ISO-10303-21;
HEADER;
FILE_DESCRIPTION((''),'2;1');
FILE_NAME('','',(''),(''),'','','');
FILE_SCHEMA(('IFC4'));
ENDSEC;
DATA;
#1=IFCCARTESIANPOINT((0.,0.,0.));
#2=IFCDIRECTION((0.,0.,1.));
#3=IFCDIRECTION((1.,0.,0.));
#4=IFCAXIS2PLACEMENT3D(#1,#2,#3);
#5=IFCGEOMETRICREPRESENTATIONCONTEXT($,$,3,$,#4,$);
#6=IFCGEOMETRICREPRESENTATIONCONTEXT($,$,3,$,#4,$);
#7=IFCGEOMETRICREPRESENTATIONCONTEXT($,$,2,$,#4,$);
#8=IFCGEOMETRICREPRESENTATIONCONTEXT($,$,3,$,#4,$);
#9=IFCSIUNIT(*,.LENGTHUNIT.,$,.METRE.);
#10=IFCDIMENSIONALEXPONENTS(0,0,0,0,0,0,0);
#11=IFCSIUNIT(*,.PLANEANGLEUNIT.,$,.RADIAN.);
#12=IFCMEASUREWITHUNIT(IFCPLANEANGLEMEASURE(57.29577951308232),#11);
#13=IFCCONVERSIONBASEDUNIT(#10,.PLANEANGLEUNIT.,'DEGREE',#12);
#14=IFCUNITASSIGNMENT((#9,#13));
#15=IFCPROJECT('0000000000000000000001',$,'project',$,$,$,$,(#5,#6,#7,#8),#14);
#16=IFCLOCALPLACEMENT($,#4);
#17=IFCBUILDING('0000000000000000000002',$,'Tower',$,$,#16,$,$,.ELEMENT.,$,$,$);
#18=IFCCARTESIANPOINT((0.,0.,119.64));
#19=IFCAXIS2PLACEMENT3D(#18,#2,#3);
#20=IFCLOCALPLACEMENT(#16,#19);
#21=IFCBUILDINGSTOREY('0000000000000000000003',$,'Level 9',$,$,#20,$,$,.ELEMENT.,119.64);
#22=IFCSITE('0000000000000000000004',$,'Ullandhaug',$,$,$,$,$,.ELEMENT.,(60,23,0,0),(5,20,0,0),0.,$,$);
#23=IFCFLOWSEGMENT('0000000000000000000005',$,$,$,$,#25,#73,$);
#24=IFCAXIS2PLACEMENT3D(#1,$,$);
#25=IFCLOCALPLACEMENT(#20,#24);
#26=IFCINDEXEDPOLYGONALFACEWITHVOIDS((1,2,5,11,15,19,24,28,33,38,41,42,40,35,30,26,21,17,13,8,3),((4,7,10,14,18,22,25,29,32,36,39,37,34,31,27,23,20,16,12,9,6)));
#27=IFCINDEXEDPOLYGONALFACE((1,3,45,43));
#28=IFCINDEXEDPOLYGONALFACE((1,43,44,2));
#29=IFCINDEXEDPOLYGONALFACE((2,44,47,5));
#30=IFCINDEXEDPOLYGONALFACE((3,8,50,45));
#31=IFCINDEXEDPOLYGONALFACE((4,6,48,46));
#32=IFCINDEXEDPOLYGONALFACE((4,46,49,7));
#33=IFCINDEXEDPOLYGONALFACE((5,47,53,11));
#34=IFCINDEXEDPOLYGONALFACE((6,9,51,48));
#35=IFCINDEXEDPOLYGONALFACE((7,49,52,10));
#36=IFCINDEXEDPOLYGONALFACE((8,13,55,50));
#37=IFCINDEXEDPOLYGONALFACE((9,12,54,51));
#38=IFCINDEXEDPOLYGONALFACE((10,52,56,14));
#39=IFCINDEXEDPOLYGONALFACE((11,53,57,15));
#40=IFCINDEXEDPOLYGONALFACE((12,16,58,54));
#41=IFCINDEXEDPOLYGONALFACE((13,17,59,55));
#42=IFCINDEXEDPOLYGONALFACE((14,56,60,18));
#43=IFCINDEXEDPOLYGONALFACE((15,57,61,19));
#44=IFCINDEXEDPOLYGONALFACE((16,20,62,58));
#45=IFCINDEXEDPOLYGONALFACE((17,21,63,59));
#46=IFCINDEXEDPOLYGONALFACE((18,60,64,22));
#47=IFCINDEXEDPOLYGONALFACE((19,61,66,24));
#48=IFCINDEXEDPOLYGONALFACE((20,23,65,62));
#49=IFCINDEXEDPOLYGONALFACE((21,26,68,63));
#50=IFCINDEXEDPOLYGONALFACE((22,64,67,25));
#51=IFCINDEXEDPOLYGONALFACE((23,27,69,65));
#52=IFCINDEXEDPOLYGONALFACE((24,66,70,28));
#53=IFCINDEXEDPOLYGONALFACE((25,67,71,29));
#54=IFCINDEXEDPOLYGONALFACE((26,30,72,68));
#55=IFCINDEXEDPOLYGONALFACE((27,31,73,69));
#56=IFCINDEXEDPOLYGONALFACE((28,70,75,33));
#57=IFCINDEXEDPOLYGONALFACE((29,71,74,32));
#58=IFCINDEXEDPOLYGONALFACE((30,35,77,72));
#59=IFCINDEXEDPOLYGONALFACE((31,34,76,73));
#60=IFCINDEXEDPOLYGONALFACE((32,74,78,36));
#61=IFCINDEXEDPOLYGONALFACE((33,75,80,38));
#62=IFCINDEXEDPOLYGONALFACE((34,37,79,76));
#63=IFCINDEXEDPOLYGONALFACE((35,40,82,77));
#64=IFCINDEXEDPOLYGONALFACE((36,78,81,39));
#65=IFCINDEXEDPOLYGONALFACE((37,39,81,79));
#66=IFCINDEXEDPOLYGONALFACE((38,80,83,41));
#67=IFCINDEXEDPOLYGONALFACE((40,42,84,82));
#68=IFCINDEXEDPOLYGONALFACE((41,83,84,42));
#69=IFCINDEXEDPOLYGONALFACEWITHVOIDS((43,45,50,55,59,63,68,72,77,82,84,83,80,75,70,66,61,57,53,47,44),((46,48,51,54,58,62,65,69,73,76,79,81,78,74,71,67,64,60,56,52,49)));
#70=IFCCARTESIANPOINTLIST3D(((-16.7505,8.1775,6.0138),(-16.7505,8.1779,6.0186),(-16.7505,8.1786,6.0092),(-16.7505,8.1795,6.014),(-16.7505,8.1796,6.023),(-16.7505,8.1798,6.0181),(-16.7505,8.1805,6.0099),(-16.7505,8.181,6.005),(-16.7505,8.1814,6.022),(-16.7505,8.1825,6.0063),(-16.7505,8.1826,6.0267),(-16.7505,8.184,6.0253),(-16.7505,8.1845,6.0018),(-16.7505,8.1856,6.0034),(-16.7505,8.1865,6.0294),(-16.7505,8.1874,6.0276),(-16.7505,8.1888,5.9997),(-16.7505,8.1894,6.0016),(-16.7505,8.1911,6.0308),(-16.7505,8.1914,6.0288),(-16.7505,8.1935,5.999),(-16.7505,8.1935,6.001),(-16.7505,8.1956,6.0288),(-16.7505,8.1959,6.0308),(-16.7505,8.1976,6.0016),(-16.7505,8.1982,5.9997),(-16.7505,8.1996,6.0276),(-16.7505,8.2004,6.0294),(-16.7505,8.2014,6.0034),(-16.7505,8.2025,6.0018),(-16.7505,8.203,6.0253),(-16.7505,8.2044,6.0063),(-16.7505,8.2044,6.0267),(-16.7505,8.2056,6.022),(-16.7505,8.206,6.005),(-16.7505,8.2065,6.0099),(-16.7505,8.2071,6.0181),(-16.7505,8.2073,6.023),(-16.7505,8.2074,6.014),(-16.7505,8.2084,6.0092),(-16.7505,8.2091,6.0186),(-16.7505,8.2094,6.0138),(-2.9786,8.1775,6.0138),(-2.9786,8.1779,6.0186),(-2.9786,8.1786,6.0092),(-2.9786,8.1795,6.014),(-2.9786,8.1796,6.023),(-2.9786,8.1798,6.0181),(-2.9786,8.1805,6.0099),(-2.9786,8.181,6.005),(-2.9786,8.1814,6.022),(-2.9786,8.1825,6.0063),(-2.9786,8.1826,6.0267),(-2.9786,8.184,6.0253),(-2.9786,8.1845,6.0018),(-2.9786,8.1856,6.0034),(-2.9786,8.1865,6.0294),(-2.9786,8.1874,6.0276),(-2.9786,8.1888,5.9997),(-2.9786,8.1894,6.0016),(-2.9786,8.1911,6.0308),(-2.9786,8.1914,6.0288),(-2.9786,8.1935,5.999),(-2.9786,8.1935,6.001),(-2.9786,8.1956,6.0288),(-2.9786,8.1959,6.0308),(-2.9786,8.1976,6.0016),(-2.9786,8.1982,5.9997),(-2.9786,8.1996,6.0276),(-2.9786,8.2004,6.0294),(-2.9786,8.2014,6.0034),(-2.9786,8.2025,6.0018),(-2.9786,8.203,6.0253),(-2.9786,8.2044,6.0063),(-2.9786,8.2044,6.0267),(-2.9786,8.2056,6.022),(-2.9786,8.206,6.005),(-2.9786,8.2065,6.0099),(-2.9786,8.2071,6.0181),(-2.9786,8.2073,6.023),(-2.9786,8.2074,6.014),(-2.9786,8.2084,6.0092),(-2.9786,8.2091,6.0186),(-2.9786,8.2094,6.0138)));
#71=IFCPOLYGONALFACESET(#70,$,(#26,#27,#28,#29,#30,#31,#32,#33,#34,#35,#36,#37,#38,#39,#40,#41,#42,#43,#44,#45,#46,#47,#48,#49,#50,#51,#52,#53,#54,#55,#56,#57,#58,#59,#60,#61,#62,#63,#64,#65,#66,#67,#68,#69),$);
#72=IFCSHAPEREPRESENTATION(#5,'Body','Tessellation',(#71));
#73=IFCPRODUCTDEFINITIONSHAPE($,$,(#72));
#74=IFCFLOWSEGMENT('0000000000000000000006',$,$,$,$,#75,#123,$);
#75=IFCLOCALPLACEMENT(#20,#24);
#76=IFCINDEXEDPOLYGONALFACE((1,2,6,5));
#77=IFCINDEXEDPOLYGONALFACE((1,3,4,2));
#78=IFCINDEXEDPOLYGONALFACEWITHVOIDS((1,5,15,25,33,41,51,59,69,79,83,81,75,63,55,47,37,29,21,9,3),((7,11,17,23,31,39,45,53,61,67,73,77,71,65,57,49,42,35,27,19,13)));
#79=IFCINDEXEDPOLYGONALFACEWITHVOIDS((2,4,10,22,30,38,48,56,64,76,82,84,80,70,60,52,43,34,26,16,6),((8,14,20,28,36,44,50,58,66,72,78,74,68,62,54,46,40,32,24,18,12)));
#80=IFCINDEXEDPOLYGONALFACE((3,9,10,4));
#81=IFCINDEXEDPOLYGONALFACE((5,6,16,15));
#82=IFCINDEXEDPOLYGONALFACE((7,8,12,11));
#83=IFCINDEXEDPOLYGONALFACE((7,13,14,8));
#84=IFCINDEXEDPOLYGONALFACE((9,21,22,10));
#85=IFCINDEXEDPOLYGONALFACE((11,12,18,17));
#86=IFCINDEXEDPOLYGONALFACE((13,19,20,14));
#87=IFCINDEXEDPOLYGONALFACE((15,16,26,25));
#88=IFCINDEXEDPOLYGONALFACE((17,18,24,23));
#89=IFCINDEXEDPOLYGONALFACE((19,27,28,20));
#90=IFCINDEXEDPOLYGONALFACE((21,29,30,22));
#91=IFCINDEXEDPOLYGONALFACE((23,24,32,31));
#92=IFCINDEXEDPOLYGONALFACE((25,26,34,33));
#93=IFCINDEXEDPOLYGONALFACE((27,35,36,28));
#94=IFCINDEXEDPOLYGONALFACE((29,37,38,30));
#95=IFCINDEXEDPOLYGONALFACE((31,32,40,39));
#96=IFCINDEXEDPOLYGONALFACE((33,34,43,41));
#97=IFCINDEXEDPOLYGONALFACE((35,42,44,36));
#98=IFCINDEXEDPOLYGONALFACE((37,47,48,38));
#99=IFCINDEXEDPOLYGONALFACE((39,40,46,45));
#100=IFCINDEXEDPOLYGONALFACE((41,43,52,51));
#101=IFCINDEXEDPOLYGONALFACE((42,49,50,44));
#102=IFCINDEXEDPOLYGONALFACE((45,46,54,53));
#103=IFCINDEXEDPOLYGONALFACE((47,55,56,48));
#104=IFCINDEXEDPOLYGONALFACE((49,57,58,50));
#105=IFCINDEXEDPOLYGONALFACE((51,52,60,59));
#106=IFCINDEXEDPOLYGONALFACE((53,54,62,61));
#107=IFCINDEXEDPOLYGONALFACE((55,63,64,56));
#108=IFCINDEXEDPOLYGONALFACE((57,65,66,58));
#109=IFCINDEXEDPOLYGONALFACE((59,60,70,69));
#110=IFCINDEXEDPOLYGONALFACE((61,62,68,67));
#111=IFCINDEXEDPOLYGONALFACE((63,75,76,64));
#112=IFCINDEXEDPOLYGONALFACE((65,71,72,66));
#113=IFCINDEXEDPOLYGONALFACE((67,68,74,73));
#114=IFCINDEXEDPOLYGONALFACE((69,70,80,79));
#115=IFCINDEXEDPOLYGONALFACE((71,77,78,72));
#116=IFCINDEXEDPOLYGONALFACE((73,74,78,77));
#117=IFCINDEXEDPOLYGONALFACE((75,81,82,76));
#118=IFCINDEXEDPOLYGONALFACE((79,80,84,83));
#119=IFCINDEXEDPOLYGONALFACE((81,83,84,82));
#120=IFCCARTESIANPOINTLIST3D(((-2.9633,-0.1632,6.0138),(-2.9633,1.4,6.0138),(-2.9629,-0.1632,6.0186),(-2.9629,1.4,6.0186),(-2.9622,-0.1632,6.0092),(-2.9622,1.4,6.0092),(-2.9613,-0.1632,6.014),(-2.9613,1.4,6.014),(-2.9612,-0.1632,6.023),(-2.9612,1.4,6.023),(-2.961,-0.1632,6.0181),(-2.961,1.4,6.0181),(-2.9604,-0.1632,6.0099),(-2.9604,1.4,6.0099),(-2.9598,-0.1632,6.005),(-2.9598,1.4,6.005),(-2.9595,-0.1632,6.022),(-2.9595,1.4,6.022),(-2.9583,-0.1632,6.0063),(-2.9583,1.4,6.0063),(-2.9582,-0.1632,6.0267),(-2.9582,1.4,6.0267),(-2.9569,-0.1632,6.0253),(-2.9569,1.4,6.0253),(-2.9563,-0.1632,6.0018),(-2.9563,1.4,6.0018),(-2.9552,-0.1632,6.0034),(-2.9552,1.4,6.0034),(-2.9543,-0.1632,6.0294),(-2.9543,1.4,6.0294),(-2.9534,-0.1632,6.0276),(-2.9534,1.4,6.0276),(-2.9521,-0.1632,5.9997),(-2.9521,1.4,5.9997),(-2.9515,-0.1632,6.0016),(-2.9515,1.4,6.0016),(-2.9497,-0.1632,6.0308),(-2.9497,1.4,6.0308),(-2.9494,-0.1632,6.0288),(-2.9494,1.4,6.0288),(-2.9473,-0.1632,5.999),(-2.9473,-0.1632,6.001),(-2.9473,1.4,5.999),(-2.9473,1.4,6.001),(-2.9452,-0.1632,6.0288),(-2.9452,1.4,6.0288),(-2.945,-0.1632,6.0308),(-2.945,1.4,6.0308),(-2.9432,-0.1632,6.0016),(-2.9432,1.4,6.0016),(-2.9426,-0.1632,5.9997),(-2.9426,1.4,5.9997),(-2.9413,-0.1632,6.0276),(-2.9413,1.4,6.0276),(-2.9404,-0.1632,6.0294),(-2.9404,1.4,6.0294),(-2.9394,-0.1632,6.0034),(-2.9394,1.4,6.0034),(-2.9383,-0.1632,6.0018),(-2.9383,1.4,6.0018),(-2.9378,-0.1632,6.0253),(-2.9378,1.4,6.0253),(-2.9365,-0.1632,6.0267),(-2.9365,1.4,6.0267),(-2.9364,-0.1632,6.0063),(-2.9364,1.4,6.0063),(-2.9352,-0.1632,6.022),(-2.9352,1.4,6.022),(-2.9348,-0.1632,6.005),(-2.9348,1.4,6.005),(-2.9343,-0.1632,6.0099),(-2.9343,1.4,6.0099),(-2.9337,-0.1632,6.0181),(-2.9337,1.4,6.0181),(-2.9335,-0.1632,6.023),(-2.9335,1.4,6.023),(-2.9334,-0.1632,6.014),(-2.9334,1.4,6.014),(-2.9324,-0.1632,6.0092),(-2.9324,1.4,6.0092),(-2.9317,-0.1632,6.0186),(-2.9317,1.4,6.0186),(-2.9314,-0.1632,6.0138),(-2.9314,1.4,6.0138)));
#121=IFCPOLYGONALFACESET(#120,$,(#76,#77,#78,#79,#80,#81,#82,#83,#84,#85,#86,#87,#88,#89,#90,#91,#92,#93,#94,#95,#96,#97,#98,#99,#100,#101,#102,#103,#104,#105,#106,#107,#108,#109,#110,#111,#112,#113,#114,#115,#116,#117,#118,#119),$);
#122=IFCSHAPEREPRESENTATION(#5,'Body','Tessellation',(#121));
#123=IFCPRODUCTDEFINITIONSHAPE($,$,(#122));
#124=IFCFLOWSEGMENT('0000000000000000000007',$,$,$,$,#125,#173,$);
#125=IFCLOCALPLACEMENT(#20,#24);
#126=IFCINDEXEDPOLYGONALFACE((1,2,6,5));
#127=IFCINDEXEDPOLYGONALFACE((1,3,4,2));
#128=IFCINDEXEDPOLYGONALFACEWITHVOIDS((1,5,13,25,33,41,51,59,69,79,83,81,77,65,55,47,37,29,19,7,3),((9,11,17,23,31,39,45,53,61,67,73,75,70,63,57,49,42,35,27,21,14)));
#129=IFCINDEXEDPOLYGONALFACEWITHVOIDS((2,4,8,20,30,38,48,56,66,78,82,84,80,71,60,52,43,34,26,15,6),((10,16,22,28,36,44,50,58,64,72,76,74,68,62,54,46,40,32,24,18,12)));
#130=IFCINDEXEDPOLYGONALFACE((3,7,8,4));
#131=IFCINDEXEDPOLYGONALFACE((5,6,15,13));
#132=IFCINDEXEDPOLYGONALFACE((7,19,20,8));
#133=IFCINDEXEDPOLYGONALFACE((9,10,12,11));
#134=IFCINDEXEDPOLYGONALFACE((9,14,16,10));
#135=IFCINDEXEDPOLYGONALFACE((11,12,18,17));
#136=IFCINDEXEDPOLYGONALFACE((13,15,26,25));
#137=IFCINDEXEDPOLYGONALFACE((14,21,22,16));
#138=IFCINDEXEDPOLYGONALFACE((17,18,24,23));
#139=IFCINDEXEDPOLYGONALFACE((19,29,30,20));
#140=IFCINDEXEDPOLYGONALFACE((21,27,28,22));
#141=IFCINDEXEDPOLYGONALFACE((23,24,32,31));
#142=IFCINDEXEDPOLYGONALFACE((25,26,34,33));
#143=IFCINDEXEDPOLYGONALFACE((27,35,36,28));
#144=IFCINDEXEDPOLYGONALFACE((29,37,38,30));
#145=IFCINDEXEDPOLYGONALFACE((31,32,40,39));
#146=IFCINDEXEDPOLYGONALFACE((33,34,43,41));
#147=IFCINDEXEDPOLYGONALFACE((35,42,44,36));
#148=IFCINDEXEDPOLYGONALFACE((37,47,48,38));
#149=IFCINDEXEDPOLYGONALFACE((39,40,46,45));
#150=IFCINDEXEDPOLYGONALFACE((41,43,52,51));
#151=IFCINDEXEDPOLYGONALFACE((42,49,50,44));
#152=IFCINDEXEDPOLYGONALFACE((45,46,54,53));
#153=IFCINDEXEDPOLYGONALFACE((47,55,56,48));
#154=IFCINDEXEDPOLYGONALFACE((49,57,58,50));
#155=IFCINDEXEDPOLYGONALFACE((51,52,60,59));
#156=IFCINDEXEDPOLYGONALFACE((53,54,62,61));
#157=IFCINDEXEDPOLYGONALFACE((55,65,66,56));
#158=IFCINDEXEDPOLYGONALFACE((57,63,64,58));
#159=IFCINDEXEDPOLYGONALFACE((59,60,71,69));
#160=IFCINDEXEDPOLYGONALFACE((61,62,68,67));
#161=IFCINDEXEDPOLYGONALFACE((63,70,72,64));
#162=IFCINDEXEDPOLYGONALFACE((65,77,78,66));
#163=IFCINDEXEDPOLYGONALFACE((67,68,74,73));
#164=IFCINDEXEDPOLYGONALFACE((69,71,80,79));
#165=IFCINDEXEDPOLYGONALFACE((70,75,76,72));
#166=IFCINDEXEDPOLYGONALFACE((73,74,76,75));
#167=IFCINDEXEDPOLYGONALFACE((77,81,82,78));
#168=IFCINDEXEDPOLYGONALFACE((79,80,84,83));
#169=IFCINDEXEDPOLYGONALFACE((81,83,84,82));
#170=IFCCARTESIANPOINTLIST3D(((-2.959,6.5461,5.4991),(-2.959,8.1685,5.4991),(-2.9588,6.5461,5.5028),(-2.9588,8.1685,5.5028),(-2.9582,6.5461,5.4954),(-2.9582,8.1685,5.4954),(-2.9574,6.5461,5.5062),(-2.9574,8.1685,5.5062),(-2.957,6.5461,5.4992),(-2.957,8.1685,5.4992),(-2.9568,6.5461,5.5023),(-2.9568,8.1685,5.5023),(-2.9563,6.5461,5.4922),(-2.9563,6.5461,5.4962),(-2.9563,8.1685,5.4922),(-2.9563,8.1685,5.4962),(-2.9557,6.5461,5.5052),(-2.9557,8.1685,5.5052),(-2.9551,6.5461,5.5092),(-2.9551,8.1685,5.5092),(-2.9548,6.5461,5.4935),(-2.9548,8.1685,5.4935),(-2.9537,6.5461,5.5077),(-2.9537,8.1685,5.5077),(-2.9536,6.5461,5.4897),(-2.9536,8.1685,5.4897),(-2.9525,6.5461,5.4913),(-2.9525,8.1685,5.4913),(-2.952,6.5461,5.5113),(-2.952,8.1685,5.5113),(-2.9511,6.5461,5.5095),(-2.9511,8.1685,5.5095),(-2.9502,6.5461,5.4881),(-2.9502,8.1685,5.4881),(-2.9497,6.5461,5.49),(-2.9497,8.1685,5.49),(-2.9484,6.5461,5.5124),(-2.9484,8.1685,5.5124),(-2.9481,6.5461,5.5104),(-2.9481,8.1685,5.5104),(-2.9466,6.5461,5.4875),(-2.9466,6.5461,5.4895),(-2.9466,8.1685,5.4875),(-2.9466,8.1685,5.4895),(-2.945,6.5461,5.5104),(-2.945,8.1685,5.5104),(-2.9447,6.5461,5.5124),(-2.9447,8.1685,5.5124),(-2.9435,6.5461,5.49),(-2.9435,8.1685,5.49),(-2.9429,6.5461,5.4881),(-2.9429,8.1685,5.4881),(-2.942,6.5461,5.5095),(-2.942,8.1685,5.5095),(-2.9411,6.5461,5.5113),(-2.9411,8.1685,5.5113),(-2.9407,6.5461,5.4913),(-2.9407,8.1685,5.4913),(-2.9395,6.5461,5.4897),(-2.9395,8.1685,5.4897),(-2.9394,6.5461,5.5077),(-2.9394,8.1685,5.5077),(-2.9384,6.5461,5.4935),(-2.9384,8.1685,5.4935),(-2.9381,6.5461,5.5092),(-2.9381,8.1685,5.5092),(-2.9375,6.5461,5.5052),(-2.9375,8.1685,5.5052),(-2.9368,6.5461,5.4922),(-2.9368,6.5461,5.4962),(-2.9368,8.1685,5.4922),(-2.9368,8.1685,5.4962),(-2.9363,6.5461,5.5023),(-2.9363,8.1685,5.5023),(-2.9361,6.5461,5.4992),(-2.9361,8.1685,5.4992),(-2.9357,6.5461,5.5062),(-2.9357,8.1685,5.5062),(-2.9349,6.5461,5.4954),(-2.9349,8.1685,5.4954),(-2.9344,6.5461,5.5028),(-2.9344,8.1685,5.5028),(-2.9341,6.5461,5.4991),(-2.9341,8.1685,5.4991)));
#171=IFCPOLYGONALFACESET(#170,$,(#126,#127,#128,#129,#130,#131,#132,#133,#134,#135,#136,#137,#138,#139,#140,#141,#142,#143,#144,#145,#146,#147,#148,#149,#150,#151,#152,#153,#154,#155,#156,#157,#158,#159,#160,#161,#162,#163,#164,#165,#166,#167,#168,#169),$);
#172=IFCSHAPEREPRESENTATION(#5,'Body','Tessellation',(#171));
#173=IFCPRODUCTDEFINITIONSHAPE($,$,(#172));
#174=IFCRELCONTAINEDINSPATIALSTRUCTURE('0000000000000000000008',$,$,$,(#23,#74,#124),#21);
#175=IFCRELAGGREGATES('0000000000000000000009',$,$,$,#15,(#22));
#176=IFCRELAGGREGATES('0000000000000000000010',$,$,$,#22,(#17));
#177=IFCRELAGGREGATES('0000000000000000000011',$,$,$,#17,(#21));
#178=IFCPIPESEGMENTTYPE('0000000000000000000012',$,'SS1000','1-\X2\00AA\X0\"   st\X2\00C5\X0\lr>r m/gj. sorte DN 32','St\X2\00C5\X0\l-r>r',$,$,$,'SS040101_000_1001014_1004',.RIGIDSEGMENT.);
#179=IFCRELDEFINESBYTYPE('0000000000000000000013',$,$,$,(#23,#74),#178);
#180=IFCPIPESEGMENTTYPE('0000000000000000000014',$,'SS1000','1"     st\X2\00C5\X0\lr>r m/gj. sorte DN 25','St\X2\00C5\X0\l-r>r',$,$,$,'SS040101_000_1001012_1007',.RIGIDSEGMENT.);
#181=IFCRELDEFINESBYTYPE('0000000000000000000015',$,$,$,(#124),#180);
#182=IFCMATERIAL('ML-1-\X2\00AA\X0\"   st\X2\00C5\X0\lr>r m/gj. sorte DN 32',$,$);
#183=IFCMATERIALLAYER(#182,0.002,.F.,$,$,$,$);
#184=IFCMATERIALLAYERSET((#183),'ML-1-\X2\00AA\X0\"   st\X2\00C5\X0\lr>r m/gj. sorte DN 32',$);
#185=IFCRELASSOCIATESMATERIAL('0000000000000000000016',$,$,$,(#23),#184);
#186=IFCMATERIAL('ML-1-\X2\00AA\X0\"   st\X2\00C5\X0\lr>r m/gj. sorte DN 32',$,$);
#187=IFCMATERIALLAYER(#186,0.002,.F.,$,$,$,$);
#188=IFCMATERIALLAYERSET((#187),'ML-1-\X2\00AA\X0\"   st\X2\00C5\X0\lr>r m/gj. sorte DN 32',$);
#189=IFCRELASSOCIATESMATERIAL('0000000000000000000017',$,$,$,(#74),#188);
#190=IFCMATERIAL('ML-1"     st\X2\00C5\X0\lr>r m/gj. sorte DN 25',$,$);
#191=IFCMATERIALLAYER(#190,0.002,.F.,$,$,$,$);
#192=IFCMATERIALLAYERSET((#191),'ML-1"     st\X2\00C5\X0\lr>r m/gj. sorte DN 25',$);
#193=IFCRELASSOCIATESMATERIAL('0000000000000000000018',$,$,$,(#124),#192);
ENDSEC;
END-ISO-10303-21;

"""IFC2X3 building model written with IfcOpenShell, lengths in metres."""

from ifc_helpers import new_model, entity, si_unit, converted_unit, frame, origin_with_axes, origin_2d_with_axis, place, context, project, spatial, hollow_circle, extrude, material, layer, layer_set, layer_usage, type_object, element, save


model = new_model("IFC2X3")

# Units and contexts
context_of_model_1 = context(None, 3, world=origin_with_axes())
context_of_model_2 = context(None, 3, world=origin_with_axes())
context_of_model_3 = context(None, 2, world=origin_with_axes())
context_of_model_4 = context(None, 3, world=origin_with_axes())
ifc_project = project(units=[si_unit("LENGTHUNIT", "METRE"), converted_unit("PLANEANGLEUNIT", "DEGREE", entity("IfcPlaneAngleMeasure", 57.29577951308232), si_unit("PLANEANGLEUNIT", "RADIAN"), dimensions=[0, 0, 0, 0, 0, 0, 0])], contexts=[context_of_model_1, context_of_model_2, context_of_model_3, context_of_model_4])

# Site, building, storey
site = spatial("IfcSite", under=ifc_project, Name="Ullandhaug", CompositionType="ELEMENT", RefLatitude=(60, 23, 0, 0), RefLongitude=(5, 20, 0, 0), RefElevation=0.0)
building_placement = place(None, origin_with_axes())
building = spatial("IfcBuilding", under=site, at=building_placement, Name="Tower", CompositionType="ELEMENT")
storey_placement = place(building_placement, frame((0.0, 0.0, 119.64), z_axis=(0.0, 0.0, 1.0), x_axis=(1.0, 0.0, 0.0)))
storey = spatial("IfcBuildingStorey", under=building, at=storey_placement, Name="Level 9", CompositionType="ELEMENT", Elevation=119.64)

# Flow segments
pipe_segment_type_1 = type_object("IfcPipeSegmentType", Name="SS1000", Description="1-ª\"   stÅlr>r m/gj. sorte DN 32", ApplicableOccurrence="StÅl-r>r", ElementType="SS040101_000_1001014_1004", PredefinedType="RIGIDSEGMENT")
ifc_material_1 = material(Name="ML-1-ª\"   stÅlr>r m/gj. sorte DN 32")
ifc_layer_1 = layer(ifc_material_1, 0.002, ventilated=False)
ifc_layer_set_1 = layer_set([ifc_layer_1], Name="ML-1-ª\"   stÅlr>r m/gj. sorte DN 32")
ifc_layer_usage_1 = layer_usage(ifc_layer_set_1, "AXIS2", "POSITIVE", 0.0)
flow_segment_1_placement = place(storey_placement, frame((-2.9786, 8.1935, 6.015), z_axis=(-1.0, 0.0, 0.0), x_axis=(0.0, 0.0, -1.0)))
element("IfcFlowSegment", 1, at=flow_segment_1_placement, inside=storey, type_object=pipe_segment_type_1, material=ifc_layer_usage_1, context=context_of_model_1, shape_type="SweptSolid", body=[
    extrude(hollow_circle(Radius=0.016, WallThickness=0.002, at=origin_2d_with_axis()), origin_with_axes(), (0.0, 0.0, 1.0), 13.7719),
])
ifc_material_2 = material(Name="ML-1-ª\"   stÅlr>r m/gj. sorte DN 32")
ifc_layer_2 = layer(ifc_material_2, 0.002, ventilated=False)
ifc_layer_set_2 = layer_set([ifc_layer_2], Name="ML-1-ª\"   stÅlr>r m/gj. sorte DN 32")
ifc_layer_usage_2 = layer_usage(ifc_layer_set_2, "AXIS2", "POSITIVE", 0.0)
flow_segment_2_placement = place(storey_placement, frame((-2.9473, -0.1632, 6.015), z_axis=(0.0, 1.0, 0.0), x_axis=(0.0, 0.0, -1.0)))
element("IfcFlowSegment", 2, at=flow_segment_2_placement, inside=storey, type_object=pipe_segment_type_1, material=ifc_layer_usage_2, context=context_of_model_1, shape_type="SweptSolid", body=[
    extrude(hollow_circle(Radius=0.016, WallThickness=0.002, at=origin_2d_with_axis()), origin_with_axes(), (0.0, 0.0, 1.0), 1.5632),
])
ifc_material_3 = material(Name="ML-1\"     stÅlr>r m/gj. sorte DN 25")
ifc_layer_3 = layer(ifc_material_3, 0.002, ventilated=False)
ifc_layer_set_3 = layer_set([ifc_layer_3], Name="ML-1\"     stÅlr>r m/gj. sorte DN 25")
ifc_layer_usage_3 = layer_usage(ifc_layer_set_3, "AXIS2", "POSITIVE", 0.0)
pipe_segment_type_2 = type_object("IfcPipeSegmentType", Name="SS1000", Description="1\"     stÅlr>r m/gj. sorte DN 25", ApplicableOccurrence="StÅl-r>r", ElementType="SS040101_000_1001012_1007", PredefinedType="RIGIDSEGMENT")
flow_segment_3_placement = place(storey_placement, frame((-2.9466, 6.5461, 5.5), z_axis=(0.0, 1.0, 0.0), x_axis=(0.0, 0.0, -1.0)))
element("IfcFlowSegment", 3, at=flow_segment_3_placement, inside=storey, type_object=pipe_segment_type_2, material=ifc_layer_usage_3, context=context_of_model_1, shape_type="SweptSolid", body=[
    extrude(hollow_circle(Radius=0.0125, WallThickness=0.002, at=origin_2d_with_axis()), origin_with_axes(), (0.0, 0.0, 1.0), 1.6224),
])

save(model, "model.ifc")
